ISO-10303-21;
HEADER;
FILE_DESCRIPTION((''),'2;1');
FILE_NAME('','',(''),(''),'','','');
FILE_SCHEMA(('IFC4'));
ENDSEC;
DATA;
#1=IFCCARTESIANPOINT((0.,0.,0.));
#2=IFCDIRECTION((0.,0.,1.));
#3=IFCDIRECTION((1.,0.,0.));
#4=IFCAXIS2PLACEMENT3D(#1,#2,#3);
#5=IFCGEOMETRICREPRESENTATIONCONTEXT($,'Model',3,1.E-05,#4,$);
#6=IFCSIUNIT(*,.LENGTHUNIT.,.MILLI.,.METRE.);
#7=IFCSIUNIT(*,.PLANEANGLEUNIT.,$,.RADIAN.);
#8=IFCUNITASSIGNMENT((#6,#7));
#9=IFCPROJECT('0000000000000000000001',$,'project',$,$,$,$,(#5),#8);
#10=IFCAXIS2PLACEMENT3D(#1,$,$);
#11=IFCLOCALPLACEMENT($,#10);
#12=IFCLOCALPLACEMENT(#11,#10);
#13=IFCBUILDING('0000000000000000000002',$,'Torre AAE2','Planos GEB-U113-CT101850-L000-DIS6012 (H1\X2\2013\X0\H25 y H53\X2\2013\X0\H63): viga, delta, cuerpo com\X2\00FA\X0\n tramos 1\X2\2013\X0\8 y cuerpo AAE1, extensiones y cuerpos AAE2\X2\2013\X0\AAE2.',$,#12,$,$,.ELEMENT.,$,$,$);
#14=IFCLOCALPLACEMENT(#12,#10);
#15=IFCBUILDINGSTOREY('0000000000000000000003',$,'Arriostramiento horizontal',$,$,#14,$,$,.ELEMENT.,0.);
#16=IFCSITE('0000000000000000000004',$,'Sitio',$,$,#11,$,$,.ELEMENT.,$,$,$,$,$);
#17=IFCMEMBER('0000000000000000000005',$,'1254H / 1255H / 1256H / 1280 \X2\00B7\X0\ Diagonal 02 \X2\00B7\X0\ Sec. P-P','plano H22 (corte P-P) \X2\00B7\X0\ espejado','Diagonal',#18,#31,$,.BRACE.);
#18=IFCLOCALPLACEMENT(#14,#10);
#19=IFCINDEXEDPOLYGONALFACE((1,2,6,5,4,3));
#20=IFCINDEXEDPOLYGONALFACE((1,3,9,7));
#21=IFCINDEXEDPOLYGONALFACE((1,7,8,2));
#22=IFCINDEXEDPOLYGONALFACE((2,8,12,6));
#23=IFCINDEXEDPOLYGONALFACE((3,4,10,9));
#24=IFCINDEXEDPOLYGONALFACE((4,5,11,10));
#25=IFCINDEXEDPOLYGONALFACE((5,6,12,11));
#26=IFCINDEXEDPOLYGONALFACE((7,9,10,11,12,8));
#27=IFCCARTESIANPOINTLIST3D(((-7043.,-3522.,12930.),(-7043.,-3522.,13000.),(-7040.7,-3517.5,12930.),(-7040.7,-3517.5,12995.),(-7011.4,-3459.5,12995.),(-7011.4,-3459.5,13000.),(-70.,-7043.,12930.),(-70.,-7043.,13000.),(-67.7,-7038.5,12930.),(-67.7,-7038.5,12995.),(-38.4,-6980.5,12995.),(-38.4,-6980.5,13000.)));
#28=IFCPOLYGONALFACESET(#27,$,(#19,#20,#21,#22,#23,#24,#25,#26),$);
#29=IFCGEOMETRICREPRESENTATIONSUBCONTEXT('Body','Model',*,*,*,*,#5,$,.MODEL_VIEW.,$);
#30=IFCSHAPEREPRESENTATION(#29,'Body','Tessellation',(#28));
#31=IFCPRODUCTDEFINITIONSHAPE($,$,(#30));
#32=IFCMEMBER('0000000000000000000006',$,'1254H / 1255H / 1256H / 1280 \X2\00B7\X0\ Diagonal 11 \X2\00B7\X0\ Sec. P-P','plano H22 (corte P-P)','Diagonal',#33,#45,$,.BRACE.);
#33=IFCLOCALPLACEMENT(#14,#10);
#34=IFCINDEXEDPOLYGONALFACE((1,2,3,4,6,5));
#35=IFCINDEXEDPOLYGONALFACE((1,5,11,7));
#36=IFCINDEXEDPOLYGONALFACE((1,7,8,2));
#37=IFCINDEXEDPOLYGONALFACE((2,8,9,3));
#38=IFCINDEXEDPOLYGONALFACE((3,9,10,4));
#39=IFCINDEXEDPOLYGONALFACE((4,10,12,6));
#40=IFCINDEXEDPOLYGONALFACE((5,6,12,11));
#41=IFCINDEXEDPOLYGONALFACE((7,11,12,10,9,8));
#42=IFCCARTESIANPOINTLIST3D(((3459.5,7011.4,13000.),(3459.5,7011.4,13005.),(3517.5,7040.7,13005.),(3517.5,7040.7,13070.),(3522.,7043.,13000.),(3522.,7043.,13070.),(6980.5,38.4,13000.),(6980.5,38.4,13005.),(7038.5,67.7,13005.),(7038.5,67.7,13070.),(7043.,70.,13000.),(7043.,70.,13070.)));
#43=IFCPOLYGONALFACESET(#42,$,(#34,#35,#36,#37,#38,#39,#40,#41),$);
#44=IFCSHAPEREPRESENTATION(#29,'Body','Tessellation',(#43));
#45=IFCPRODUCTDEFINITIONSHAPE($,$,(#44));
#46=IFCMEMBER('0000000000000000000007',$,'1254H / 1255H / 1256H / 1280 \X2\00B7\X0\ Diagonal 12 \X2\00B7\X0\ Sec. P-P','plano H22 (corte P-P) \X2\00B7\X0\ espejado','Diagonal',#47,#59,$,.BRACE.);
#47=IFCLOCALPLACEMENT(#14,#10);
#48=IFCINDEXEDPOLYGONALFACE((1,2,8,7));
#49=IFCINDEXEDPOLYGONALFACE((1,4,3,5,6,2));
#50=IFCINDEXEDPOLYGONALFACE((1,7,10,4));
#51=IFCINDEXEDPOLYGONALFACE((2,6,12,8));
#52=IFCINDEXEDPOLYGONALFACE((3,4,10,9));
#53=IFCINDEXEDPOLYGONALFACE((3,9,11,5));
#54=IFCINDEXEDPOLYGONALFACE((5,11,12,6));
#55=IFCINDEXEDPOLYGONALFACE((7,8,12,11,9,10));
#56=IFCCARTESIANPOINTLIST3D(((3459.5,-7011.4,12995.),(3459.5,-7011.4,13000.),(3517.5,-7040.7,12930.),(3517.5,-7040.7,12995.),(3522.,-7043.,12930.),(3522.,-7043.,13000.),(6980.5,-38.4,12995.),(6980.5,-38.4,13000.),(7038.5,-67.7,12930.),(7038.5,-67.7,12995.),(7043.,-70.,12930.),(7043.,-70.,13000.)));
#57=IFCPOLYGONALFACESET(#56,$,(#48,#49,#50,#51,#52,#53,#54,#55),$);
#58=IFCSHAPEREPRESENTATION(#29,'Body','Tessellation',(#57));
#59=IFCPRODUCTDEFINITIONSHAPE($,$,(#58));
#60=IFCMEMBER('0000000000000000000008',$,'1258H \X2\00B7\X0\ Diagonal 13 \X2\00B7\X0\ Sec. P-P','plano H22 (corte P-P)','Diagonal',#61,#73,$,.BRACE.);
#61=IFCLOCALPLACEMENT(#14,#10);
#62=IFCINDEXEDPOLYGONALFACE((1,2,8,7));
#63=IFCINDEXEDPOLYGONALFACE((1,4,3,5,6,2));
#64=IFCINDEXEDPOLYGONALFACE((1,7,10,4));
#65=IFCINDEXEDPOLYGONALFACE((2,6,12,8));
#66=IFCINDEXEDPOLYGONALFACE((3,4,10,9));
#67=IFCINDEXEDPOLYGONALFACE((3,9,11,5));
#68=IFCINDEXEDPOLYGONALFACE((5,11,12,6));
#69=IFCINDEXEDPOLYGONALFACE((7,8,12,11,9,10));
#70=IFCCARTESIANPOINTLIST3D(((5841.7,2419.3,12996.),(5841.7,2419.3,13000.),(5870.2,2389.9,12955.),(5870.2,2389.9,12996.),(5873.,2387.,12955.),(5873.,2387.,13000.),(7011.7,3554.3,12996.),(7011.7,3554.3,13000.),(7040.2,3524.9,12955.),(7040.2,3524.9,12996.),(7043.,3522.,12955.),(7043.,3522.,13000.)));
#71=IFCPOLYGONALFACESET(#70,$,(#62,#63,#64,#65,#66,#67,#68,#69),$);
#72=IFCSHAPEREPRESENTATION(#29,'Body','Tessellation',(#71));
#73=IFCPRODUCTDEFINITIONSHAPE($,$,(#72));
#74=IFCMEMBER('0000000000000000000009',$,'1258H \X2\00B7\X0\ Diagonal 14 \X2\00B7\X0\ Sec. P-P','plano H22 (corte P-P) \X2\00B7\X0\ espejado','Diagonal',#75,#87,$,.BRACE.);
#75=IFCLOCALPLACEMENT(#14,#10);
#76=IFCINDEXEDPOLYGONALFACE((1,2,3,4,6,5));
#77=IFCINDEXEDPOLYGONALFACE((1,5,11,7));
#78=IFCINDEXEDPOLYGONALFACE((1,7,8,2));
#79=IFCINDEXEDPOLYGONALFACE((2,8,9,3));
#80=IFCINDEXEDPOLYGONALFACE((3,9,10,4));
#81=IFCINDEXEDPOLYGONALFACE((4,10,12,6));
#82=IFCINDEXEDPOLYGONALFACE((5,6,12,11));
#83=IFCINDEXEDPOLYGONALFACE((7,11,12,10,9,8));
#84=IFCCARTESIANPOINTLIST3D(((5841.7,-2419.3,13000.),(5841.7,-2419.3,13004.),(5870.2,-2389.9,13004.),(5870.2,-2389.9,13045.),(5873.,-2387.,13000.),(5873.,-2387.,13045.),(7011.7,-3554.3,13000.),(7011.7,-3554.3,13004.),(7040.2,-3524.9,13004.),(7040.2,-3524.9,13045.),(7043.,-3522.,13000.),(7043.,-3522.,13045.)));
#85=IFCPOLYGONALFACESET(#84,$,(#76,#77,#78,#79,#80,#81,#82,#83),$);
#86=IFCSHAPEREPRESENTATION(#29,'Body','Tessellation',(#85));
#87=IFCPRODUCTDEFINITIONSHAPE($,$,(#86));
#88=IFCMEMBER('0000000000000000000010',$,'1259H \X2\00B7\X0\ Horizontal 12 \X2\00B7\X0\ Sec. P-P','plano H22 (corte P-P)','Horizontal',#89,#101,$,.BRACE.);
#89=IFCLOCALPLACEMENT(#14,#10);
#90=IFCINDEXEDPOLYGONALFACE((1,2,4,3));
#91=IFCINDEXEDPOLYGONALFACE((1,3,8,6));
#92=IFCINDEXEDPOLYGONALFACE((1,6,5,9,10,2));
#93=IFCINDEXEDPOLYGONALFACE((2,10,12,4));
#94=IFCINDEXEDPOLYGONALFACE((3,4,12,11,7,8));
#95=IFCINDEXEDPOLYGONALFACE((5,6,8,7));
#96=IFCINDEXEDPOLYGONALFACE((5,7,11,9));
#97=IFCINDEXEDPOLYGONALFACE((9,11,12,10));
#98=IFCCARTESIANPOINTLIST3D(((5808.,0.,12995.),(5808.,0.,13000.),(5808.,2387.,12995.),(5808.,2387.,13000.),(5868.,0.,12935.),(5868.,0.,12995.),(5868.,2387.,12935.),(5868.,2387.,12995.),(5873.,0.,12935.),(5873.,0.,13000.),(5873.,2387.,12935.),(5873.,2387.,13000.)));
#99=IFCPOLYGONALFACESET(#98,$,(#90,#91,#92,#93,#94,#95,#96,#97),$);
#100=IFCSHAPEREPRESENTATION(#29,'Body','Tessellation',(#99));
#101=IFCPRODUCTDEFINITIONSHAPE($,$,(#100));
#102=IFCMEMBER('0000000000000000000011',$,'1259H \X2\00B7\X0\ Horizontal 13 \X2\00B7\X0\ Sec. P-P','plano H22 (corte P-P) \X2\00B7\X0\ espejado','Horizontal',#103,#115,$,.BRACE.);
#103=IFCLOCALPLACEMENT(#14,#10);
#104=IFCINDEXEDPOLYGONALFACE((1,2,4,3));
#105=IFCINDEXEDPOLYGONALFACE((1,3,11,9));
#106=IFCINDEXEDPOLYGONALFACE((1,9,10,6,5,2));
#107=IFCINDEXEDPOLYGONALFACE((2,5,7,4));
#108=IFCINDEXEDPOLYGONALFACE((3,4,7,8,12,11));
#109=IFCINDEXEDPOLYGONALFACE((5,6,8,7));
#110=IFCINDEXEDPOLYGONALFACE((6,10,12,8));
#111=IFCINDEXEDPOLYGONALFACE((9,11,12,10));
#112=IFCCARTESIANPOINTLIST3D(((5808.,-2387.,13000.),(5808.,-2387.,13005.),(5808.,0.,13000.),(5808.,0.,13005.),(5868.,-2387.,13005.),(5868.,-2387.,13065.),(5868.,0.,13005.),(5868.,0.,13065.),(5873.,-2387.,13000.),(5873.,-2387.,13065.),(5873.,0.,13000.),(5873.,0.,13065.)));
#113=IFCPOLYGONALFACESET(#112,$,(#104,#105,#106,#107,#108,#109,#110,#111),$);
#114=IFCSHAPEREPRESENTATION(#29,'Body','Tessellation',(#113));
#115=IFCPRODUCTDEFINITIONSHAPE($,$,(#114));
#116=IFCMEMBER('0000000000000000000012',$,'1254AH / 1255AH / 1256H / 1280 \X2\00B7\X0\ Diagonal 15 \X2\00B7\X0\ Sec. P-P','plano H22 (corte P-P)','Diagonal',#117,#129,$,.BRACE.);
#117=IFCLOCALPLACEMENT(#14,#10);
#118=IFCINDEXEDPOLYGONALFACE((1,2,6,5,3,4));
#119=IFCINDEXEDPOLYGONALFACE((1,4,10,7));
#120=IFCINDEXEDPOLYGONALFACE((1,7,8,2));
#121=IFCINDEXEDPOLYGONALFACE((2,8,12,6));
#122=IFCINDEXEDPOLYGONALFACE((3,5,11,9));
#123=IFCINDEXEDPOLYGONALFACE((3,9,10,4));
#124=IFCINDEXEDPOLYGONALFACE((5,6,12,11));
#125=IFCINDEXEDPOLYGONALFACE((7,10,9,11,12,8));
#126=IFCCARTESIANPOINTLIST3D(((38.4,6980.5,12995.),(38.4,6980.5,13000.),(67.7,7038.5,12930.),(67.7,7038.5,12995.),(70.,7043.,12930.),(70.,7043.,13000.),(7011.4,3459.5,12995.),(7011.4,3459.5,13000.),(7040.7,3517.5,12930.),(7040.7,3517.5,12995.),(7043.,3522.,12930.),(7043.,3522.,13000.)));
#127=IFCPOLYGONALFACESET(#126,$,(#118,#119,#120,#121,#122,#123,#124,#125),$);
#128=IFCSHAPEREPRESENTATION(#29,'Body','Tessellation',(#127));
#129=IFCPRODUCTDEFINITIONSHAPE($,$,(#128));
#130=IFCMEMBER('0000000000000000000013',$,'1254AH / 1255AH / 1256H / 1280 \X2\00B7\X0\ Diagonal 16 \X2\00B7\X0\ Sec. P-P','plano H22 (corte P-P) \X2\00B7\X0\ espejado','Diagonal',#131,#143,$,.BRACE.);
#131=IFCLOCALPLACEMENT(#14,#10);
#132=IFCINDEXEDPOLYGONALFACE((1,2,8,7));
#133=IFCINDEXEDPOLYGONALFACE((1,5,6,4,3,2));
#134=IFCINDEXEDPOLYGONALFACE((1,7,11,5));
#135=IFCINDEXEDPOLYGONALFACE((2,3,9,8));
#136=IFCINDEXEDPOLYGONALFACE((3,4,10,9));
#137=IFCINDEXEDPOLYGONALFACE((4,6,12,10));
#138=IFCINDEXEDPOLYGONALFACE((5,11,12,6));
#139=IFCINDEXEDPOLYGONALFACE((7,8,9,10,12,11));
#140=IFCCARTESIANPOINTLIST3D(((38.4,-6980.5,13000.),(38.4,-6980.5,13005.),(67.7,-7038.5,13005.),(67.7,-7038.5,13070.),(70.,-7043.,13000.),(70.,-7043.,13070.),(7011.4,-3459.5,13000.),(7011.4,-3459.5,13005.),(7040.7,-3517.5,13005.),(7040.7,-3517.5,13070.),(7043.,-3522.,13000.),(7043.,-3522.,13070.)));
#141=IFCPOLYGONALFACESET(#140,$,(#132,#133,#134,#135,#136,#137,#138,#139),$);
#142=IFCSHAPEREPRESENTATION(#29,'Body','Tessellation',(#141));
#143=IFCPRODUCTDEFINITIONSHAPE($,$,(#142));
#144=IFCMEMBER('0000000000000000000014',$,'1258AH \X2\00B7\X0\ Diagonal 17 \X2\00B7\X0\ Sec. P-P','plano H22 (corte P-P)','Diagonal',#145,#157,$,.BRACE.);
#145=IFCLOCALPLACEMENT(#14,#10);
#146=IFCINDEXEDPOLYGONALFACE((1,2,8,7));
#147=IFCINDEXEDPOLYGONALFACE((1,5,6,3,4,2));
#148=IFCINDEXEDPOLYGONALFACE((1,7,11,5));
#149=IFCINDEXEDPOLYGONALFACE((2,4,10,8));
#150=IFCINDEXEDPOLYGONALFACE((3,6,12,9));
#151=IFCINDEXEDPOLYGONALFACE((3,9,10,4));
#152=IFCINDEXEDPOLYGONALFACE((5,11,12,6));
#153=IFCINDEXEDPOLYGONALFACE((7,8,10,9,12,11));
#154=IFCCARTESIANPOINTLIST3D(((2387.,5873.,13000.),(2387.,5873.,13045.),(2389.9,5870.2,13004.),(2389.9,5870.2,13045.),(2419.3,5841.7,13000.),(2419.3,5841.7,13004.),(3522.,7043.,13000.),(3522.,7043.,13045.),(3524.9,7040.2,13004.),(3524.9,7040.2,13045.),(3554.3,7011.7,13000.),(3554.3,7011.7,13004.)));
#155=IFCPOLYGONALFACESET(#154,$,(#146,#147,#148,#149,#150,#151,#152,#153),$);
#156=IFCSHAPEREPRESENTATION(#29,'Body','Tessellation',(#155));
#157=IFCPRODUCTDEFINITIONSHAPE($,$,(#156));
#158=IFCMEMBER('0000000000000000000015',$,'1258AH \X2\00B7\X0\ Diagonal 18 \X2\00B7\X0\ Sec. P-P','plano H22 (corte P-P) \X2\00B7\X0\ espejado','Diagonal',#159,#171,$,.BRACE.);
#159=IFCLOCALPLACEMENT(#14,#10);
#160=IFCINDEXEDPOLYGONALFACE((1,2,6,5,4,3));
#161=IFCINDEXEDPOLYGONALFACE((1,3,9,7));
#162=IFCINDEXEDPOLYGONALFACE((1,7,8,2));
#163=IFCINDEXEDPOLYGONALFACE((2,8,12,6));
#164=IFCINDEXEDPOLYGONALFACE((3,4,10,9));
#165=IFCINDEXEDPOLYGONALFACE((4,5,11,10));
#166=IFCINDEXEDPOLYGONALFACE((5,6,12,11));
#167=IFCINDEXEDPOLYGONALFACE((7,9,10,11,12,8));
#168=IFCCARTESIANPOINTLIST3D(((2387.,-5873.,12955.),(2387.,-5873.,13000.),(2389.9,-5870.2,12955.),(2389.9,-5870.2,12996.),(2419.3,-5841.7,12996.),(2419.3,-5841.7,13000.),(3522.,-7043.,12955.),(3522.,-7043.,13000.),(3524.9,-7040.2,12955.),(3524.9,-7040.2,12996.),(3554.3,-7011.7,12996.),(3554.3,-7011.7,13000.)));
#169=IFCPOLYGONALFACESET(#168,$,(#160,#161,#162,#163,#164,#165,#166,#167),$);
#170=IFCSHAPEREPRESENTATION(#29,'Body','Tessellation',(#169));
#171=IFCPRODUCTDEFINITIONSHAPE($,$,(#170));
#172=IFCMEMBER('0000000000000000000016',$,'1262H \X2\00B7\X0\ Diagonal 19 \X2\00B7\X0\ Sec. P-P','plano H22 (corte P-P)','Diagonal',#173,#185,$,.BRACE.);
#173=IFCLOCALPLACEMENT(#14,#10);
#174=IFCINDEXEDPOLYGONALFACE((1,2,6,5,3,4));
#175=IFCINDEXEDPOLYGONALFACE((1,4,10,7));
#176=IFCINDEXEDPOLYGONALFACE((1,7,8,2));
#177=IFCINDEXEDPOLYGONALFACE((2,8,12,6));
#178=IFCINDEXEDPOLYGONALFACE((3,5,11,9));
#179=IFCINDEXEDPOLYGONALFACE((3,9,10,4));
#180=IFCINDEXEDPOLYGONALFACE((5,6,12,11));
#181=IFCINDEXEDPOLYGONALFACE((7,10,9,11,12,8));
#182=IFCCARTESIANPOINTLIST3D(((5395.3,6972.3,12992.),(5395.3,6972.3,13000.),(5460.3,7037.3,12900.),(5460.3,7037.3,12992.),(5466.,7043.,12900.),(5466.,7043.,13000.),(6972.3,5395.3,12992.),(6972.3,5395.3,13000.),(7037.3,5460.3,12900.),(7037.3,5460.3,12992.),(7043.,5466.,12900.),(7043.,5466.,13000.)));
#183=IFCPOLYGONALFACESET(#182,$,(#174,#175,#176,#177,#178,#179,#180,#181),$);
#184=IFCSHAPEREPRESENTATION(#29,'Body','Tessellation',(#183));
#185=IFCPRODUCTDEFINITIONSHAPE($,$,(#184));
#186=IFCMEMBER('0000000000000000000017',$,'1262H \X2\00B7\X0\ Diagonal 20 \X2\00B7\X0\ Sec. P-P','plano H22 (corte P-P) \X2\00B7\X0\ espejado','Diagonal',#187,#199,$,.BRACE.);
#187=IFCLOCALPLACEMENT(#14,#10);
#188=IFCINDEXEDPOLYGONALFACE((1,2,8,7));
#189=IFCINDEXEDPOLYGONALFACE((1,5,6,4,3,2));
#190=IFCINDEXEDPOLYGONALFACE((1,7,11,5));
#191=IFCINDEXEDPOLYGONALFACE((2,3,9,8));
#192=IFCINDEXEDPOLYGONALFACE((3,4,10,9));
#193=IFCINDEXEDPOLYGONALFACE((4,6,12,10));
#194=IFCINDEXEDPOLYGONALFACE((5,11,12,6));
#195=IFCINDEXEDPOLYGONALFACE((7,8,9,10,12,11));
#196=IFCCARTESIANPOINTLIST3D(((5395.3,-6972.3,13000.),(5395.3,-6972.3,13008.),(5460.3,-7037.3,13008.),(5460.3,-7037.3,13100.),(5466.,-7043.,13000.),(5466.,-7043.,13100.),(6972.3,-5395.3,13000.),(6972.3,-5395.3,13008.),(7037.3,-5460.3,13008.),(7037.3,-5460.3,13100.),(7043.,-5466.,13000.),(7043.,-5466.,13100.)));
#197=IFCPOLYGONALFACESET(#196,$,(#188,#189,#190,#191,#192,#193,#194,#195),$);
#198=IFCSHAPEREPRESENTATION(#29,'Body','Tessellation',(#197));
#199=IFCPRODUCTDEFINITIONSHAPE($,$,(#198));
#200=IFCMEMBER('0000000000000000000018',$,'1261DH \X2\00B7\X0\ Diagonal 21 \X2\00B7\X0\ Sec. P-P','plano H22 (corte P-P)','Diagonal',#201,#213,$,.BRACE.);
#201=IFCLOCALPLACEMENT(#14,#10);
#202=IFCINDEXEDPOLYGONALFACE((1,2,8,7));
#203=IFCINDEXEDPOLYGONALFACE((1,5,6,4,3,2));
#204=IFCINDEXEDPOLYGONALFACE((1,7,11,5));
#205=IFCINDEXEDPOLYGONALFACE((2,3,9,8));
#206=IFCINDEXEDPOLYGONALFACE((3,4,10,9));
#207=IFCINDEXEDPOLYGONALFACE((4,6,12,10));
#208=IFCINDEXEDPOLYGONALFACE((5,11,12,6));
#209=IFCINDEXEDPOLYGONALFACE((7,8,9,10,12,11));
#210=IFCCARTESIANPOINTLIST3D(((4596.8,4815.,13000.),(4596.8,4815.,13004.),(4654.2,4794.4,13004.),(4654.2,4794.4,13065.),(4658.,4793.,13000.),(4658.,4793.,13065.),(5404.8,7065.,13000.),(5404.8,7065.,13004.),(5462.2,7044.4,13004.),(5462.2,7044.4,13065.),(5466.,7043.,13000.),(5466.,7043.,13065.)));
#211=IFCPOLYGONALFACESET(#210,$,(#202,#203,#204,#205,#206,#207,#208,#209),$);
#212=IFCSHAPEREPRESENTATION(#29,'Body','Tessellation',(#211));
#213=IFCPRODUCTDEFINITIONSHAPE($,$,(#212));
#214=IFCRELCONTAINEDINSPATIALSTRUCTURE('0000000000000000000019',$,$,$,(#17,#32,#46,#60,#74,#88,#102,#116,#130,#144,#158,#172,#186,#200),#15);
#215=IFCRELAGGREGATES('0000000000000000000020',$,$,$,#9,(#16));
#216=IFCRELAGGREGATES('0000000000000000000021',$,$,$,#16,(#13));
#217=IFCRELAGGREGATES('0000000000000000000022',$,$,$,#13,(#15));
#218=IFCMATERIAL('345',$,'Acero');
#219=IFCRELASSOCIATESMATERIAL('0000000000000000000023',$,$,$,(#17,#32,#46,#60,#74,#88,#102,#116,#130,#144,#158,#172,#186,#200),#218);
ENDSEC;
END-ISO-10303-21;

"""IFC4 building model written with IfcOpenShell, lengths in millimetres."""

from ifc_helpers import new_model, si_unit, frame, frame_2d, origin, origin_with_axes, place, context, subcontext, project, spatial, l_section, extrude, material, element, save


model = new_model("IFC4")

# Units and contexts
model_context = context("Model", 3, precision=1e-05, world=origin_with_axes())
body_context = subcontext(model_context, "Body", "Model", "MODEL_VIEW")
ifc_project = project(units=[si_unit("LENGTHUNIT", "METRE", prefix="MILLI"), si_unit("PLANEANGLEUNIT", "RADIAN")], contexts=[model_context])

# Site, building, storey
site_placement = place(None, origin())
site = spatial("IfcSite", under=ifc_project, at=site_placement, Name="Sitio", CompositionType="ELEMENT")
building_placement = place(site_placement, origin())
building = spatial("IfcBuilding", under=site, at=building_placement, Name="Torre AAE2", Description="Planos GEB-U113-CT101850-L000-DIS6012 (H1–H25 y H53–H63): viga, delta, cuerpo común tramos 1–8 y cuerpo AAE1, extensiones y cuerpos AAE2–AAE2.", CompositionType="ELEMENT")
storey_placement = place(building_placement, origin())
storey = spatial("IfcBuildingStorey", under=building, at=storey_placement, Name="Arriostramiento horizontal", CompositionType="ELEMENT", Elevation=0.0)

# Members
ifc_material_1 = material(Name="345", Category="Acero")
for number, where, z_axis, x_axis, name, description in (
    (1, (-70.0, -7043.0, 13000.0), (-0.892654, 0.450743, 0.0), (0.450743, 0.892654, 0.0), "1254H / 1255H / 1256H / 1280 · Diagonal 02 · Sec. P-P", "plano H22 (corte P-P) · espejado"),
    (2, (7043.0, 70.0, 13000.0), (-0.450743, 0.892654, 0.0), (-0.892654, -0.450743, 0.0), "1254H / 1255H / 1256H / 1280 · Diagonal 11 · Sec. P-P", "plano H22 (corte P-P)"),
    (3, (7043.0, -70.0, 13000.0), (-0.450743, -0.892654, 0.0), (-0.892654, 0.450743, 0.0), "1254H / 1255H / 1256H / 1280 · Diagonal 12 · Sec. P-P", "plano H22 (corte P-P) · espejado"),
):
    element("IfcMember", number, at=place(storey_placement, frame(where, z_axis=z_axis, x_axis=x_axis)), inside=storey, material=ifc_material_1, Name=name, Description=description, ObjectType="Diagonal", PredefinedType="BRACE", context=body_context, shape_type="SweptSolid", body=[
        extrude(l_section(Depth=70.0, Width=70.0, Thickness=5.0, at=frame_2d((35.0, 35.0))), None, (0.0, 0.0, 1.0), 7811.5),
    ])
for number, where, z_axis, x_axis, name, description in (
    (4, (7043.0, 3522.0, 13000.0), (-0.717761, -0.69629, 0.0), (-0.69629, 0.717761, 0.0), "1258H · Diagonal 13 · Sec. P-P", "plano H22 (corte P-P)"),
    (5, (7043.0, -3522.0, 13000.0), (-0.717761, 0.69629, 0.0), (-0.69629, -0.717761, 0.0), "1258H · Diagonal 14 · Sec. P-P", "plano H22 (corte P-P) · espejado"),
):
    element("IfcMember", number, at=place(storey_placement, frame(where, z_axis=z_axis, x_axis=x_axis)), inside=storey, material=ifc_material_1, Name=name, Description=description, ObjectType="Diagonal", PredefinedType="BRACE", context=body_context, shape_type="SweptSolid", body=[
        extrude(l_section(Depth=45.0, Width=45.0, Thickness=4.0, at=frame_2d((22.5, 22.5))), None, (0.0, 0.0, 1.0), 1630.1),
    ])
for number, where, z_axis, x_axis, name, description in (
    (6, (5873.0, 2387.0, 13000.0), (0.0, -1.0, 0.0), (-1.0, 0.0, 0.0), "1259H · Horizontal 12 · Sec. P-P", "plano H22 (corte P-P)"),
    (7, (5873.0, -2387.0, 13000.0), (0.0, 1.0, 0.0), (-1.0, 0.0, 0.0), "1259H · Horizontal 13 · Sec. P-P", "plano H22 (corte P-P) · espejado"),
):
    element("IfcMember", number, at=place(storey_placement, frame(where, z_axis=z_axis, x_axis=x_axis)), inside=storey, material=ifc_material_1, Name=name, Description=description, ObjectType="Horizontal", PredefinedType="BRACE", context=body_context, shape_type="SweptSolid", body=[
        extrude(l_section(Depth=65.0, Width=65.0, Thickness=5.0, at=frame_2d((32.5, 32.5))), None, (0.0, 0.0, 1.0), 2387.0),
    ])
for number, where, z_axis, x_axis, name, description in (
    (8, (70.0, 7043.0, 13000.0), (0.892654, -0.450743, 0.0), (-0.450743, -0.892654, 0.0), "1254AH / 1255AH / 1256H / 1280 · Diagonal 15 · Sec. P-P", "plano H22 (corte P-P)"),
    (9, (70.0, -7043.0, 13000.0), (0.892654, 0.450743, 0.0), (-0.450743, 0.892654, 0.0), "1254AH / 1255AH / 1256H / 1280 · Diagonal 16 · Sec. P-P", "plano H22 (corte P-P) · espejado"),
):
    element("IfcMember", number, at=place(storey_placement, frame(where, z_axis=z_axis, x_axis=x_axis)), inside=storey, material=ifc_material_1, Name=name, Description=description, ObjectType="Diagonal", PredefinedType="BRACE", context=body_context, shape_type="SweptSolid", body=[
        extrude(l_section(Depth=70.0, Width=70.0, Thickness=5.0, at=frame_2d((35.0, 35.0))), None, (0.0, 0.0, 1.0), 7811.5),
    ])
for number, where, z_axis, x_axis, name, description in (
    (10, (3522.0, 7043.0, 13000.0), (-0.69629, -0.717761, 0.0), (0.717761, -0.69629, 0.0), "1258AH · Diagonal 17 · Sec. P-P", "plano H22 (corte P-P)"),
    (11, (3522.0, -7043.0, 13000.0), (-0.69629, 0.717761, 0.0), (0.717761, 0.69629, 0.0), "1258AH · Diagonal 18 · Sec. P-P", "plano H22 (corte P-P) · espejado"),
):
    element("IfcMember", number, at=place(storey_placement, frame(where, z_axis=z_axis, x_axis=x_axis)), inside=storey, material=ifc_material_1, Name=name, Description=description, ObjectType="Diagonal", PredefinedType="BRACE", context=body_context, shape_type="SweptSolid", body=[
        extrude(l_section(Depth=45.0, Width=45.0, Thickness=4.0, at=frame_2d((22.5, 22.5))), None, (0.0, 0.0, 1.0), 1630.1),
    ])
for number, where, z_axis, x_axis, name, description in (
    (12, (5466.0, 7043.0, 13000.0), (0.707107, -0.707107, 0.0), (-0.707107, -0.707107, 0.0), "1262H · Diagonal 19 · Sec. P-P", "plano H22 (corte P-P)"),
    (13, (5466.0, -7043.0, 13000.0), (0.707107, 0.707107, 0.0), (-0.707107, 0.707107, 0.0), "1262H · Diagonal 20 · Sec. P-P", "plano H22 (corte P-P) · espejado"),
):
    element("IfcMember", number, at=place(storey_placement, frame(where, z_axis=z_axis, x_axis=x_axis)), inside=storey, material=ifc_material_1, Name=name, Description=description, ObjectType="Diagonal", PredefinedType="BRACE", context=body_context, shape_type="SweptSolid", body=[
        extrude(l_section(Depth=100.0, Width=100.0, Thickness=8.0, at=frame_2d((50.0, 50.0))), None, (0.0, 0.0, 1.0), 2230.2),
    ])
for number, where, z_axis, x_axis, name in (
    (14, (4658.0, 4793.0, 13000.0), (0.337979, 0.941154, 0.0), (-0.941154, 0.337979, 0.0), "1261DH · Diagonal 21 · Sec. P-P"),
):
    element("IfcMember", number, at=place(storey_placement, frame(where, z_axis=z_axis, x_axis=x_axis)), inside=storey, material=ifc_material_1, Name=name, Description="plano H22 (corte P-P)", ObjectType="Diagonal", PredefinedType="BRACE", context=body_context, shape_type="SweptSolid", body=[
        extrude(l_section(Depth=65.0, Width=65.0, Thickness=4.0, at=frame_2d((32.5, 32.5))), None, (0.0, 0.0, 1.0), 2390.7),
    ])

save(model, "model.ifc")
